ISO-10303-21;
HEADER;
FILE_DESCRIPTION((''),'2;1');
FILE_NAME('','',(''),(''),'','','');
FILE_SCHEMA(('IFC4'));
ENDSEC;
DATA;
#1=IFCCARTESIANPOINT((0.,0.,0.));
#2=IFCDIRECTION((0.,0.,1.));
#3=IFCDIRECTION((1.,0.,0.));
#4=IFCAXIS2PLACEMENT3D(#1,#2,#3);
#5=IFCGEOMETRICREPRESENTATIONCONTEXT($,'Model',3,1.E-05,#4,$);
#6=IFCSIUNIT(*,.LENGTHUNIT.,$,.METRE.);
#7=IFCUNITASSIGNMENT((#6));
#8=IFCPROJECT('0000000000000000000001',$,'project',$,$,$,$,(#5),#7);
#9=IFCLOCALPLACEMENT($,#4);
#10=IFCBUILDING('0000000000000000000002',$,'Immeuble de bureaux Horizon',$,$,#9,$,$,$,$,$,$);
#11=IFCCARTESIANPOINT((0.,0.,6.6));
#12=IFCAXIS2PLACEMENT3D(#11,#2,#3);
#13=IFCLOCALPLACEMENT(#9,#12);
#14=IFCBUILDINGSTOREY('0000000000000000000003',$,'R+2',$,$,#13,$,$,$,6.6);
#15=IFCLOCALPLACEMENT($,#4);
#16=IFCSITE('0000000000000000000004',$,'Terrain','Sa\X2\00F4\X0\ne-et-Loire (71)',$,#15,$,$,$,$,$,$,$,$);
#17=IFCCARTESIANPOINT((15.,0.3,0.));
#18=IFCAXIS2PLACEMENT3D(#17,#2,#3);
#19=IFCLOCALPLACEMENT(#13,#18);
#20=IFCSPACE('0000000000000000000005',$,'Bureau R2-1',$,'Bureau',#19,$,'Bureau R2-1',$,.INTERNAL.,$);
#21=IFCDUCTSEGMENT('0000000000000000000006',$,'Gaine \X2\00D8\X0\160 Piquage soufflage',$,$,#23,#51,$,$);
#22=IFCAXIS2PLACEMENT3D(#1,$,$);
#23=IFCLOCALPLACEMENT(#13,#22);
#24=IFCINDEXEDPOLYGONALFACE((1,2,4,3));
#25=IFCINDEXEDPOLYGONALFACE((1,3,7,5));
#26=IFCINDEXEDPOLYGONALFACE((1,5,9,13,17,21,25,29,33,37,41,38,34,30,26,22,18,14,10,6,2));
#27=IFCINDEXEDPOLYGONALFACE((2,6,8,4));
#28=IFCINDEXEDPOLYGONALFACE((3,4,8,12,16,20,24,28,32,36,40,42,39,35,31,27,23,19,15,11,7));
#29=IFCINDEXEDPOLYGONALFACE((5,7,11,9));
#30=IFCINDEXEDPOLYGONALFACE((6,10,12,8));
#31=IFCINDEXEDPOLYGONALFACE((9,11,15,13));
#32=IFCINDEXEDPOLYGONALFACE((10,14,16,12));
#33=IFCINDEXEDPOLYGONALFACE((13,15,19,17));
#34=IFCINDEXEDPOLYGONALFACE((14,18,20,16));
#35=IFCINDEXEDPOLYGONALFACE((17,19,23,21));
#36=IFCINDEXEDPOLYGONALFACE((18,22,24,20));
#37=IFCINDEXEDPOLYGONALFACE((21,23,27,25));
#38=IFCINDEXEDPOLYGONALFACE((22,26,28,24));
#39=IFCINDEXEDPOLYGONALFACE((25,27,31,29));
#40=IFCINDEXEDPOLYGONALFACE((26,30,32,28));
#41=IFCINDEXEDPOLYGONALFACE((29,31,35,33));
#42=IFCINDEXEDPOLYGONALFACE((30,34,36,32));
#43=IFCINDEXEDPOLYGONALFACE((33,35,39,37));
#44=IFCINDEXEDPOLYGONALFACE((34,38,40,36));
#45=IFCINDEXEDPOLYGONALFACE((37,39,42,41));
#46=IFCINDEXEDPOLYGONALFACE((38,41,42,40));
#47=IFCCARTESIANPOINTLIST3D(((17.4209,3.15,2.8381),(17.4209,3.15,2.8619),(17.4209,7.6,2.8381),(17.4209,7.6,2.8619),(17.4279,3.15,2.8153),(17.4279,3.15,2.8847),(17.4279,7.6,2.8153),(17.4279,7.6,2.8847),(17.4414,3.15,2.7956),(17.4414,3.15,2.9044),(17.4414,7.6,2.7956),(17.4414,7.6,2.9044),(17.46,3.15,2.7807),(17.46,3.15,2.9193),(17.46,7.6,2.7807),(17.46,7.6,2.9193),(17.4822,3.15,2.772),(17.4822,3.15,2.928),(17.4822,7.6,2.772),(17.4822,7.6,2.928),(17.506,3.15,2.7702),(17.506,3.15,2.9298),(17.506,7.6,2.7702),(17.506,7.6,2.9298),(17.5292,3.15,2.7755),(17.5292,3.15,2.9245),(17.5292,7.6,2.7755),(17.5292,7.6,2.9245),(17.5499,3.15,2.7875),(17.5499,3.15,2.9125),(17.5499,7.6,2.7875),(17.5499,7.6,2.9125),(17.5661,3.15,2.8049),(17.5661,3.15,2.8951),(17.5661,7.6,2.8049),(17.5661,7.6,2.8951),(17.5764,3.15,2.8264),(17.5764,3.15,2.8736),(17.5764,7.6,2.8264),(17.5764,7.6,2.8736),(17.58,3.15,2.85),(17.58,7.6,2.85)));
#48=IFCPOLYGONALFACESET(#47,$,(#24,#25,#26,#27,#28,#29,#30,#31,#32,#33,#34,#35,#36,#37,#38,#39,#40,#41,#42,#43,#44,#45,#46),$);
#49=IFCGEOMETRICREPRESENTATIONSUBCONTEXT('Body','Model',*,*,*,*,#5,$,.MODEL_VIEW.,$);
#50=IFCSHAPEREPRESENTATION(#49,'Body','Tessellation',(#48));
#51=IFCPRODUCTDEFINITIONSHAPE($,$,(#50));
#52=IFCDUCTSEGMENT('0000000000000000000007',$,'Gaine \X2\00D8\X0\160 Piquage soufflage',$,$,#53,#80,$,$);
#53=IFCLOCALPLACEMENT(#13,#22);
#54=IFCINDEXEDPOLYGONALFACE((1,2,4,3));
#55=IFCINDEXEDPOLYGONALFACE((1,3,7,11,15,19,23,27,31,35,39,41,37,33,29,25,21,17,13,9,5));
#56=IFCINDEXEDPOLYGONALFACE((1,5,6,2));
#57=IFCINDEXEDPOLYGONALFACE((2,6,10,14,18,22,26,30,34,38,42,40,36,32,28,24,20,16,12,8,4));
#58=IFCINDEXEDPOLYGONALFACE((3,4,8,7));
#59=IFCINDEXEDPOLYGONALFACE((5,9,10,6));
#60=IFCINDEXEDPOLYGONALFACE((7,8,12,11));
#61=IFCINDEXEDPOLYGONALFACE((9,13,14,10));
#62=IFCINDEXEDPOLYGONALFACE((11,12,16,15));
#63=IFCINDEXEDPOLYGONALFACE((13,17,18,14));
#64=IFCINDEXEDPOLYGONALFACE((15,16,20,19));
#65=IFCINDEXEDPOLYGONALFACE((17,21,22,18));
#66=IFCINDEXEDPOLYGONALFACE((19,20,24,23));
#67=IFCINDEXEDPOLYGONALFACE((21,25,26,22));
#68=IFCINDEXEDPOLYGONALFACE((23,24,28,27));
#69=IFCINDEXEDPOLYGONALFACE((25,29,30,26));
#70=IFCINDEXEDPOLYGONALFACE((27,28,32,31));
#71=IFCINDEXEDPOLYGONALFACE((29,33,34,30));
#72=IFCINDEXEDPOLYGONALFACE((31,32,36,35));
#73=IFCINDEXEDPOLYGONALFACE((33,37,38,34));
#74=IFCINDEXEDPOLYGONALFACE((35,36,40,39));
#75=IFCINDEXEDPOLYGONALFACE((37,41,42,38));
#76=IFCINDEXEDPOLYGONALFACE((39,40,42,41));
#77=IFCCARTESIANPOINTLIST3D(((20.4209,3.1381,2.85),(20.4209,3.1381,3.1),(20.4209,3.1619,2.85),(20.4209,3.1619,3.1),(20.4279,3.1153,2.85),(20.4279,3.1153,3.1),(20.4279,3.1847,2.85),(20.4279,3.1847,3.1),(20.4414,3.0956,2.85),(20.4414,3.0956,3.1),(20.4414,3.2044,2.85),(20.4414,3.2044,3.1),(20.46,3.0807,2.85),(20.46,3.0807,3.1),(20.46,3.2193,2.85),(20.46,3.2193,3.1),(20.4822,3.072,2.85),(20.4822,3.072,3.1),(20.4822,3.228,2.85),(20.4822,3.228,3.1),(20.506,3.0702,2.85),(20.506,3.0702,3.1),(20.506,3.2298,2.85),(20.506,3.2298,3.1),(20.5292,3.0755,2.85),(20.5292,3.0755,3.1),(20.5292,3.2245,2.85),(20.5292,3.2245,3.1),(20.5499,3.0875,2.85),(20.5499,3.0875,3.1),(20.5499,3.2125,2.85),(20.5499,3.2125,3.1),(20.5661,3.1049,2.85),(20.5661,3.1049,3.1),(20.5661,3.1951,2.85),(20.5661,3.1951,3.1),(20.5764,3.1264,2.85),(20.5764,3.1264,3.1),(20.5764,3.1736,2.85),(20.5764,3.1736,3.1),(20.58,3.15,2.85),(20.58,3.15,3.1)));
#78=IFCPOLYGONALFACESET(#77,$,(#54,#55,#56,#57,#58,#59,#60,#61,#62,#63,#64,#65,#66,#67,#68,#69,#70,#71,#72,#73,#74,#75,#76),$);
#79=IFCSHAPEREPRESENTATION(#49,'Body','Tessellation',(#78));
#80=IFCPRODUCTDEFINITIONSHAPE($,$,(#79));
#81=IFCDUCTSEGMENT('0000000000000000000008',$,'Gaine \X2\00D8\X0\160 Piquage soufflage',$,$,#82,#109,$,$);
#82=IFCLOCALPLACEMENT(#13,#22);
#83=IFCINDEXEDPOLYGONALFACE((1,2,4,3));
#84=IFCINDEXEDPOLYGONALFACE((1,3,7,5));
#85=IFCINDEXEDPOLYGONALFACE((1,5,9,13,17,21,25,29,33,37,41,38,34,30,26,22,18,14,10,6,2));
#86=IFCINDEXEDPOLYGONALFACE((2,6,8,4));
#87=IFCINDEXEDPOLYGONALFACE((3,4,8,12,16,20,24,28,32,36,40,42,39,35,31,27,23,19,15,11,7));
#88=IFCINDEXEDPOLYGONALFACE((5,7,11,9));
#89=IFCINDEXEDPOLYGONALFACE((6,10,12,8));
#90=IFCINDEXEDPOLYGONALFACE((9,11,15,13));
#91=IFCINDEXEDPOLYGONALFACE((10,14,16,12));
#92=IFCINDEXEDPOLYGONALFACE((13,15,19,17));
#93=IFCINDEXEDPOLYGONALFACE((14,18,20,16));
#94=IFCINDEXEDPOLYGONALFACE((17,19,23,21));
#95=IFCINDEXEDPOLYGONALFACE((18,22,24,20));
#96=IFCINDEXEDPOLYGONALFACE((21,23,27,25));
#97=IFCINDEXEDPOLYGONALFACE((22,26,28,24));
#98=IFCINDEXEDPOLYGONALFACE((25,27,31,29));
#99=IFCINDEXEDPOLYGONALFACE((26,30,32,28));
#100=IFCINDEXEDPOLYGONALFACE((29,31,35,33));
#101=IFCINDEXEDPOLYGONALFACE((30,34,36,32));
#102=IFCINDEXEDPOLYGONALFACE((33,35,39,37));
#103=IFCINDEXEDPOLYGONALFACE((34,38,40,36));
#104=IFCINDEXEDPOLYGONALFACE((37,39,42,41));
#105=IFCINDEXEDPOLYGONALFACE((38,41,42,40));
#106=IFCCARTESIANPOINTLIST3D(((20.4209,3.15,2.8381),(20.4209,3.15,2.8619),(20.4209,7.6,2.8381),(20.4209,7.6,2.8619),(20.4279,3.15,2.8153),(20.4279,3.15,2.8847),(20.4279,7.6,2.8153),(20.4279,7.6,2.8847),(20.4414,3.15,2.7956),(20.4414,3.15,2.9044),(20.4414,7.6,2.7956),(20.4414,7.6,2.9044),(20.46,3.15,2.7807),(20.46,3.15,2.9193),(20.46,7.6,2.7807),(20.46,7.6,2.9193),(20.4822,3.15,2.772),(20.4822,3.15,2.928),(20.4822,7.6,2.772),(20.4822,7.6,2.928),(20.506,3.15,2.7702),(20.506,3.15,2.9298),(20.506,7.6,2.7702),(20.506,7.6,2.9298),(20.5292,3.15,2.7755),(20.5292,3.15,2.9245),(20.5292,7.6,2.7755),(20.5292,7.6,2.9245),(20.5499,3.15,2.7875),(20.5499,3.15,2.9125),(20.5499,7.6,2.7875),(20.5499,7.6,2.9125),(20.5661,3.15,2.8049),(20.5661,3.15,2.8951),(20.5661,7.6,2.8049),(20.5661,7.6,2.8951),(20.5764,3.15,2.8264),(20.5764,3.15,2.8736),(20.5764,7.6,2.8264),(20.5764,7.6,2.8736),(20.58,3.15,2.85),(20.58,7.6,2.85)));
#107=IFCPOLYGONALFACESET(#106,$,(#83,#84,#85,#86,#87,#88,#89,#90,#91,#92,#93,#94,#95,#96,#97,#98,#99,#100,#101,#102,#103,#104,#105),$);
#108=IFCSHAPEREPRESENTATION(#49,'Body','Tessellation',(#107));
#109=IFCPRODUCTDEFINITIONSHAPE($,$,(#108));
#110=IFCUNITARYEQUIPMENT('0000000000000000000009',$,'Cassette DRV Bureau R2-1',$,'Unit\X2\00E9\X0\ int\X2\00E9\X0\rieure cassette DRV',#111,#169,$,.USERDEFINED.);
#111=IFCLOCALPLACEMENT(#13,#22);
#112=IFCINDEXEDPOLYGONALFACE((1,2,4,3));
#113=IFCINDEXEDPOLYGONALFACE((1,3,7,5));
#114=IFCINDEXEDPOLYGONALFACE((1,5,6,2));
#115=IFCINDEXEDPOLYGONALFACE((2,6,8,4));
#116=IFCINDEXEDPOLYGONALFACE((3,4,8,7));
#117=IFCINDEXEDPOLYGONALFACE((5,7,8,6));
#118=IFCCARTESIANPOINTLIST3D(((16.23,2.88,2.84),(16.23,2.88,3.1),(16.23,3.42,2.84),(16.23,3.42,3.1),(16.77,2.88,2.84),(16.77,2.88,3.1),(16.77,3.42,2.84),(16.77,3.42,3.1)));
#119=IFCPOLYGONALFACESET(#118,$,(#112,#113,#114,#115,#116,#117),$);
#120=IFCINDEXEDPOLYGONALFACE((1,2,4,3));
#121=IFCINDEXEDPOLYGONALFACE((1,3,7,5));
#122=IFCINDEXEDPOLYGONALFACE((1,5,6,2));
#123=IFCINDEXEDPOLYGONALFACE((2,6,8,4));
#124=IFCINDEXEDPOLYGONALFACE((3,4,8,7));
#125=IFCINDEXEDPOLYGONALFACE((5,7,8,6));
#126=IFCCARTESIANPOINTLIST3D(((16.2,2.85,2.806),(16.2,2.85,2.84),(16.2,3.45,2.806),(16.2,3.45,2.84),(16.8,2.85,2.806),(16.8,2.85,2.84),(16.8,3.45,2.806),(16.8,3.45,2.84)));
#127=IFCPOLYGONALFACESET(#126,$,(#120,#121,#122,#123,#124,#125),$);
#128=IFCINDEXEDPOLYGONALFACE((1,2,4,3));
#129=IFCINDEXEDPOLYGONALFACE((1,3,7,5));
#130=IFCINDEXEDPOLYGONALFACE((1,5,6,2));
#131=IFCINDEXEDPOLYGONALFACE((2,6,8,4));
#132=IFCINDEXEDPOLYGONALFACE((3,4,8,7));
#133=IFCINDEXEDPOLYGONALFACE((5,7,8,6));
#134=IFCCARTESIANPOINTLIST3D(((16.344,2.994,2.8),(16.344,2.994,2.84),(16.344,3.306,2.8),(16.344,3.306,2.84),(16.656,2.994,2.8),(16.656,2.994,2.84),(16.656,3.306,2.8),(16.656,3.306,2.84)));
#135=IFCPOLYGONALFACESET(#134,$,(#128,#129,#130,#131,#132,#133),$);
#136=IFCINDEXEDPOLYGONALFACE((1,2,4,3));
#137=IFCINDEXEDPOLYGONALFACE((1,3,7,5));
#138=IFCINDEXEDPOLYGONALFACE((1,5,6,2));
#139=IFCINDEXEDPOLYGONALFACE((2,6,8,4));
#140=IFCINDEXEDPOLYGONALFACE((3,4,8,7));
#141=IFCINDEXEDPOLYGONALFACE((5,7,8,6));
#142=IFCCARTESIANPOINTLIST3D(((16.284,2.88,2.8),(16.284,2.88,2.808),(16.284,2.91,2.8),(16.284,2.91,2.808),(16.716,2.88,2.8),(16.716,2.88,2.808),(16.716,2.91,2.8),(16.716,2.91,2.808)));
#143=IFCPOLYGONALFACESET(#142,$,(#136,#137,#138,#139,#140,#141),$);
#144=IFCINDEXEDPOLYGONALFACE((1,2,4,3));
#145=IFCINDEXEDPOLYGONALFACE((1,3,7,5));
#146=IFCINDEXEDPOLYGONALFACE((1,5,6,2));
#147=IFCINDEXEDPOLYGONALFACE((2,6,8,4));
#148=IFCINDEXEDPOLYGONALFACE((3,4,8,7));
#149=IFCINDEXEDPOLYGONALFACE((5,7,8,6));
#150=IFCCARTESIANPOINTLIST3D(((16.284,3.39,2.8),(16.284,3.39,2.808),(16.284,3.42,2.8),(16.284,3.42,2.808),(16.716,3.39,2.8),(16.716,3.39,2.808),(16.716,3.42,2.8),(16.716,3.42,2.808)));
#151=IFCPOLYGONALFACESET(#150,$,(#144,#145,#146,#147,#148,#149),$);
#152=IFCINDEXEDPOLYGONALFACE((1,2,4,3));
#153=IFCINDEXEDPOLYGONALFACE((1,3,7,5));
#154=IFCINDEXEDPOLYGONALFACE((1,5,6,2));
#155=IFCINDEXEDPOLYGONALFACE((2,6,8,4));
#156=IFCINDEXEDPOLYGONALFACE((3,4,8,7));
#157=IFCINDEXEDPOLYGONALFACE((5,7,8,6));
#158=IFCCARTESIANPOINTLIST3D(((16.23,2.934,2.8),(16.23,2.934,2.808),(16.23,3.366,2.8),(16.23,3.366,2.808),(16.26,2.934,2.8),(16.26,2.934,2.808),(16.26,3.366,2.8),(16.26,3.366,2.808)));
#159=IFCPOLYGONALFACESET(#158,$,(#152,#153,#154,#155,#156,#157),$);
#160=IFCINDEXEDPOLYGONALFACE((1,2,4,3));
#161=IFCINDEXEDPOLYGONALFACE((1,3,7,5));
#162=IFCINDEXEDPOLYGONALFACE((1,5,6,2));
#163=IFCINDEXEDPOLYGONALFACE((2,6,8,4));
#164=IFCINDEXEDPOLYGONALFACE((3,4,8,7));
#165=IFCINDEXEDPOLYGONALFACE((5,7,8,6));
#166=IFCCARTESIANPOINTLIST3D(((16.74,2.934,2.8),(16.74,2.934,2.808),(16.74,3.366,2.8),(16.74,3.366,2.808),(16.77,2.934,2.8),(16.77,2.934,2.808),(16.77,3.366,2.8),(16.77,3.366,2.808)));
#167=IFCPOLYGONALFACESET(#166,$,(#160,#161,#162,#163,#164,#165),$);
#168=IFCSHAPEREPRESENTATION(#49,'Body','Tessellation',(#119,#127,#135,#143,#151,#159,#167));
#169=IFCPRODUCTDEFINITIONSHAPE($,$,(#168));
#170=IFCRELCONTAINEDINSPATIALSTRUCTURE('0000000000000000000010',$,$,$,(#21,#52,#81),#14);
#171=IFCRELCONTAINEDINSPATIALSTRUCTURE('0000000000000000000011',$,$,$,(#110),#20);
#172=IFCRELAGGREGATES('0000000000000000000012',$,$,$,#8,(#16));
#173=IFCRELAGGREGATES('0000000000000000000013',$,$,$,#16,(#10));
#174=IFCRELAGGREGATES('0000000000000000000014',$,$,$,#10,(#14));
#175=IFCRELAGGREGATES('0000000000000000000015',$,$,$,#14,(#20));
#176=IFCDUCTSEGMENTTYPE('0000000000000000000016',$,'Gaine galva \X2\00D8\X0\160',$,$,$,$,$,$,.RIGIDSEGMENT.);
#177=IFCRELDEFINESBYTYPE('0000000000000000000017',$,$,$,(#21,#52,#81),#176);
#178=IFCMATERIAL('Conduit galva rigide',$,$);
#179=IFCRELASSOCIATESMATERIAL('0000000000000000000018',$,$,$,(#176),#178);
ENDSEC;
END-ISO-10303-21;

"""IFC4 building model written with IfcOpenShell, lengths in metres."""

from ifc_helpers import new_model, si_unit, frame, frame_2d, origin_with_axes, place, context, subcontext, project, spatial, rectangle, circle, extrude, material, type_object, element, save


model = new_model("IFC4")

# Units and contexts
model_context = context("Model", 3, precision=1e-05, world=origin_with_axes())
body_context = subcontext(model_context, "Body", "Model", "MODEL_VIEW")
ifc_project = project(units=[si_unit("LENGTHUNIT", "METRE")], contexts=[model_context])

# Site, building, storey
site_placement = place(None, origin_with_axes())
site = spatial("IfcSite", under=ifc_project, at=site_placement, Name="Terrain", Description="Saône-et-Loire (71)")
building_placement = place(None, origin_with_axes())
building = spatial("IfcBuilding", under=site, at=building_placement, Name="Immeuble de bureaux Horizon")
storey_placement = place(building_placement, frame((0.0, 0.0, 6.6), z_axis=(0.0, 0.0, 1.0), x_axis=(1.0, 0.0, 0.0)))
storey = spatial("IfcBuildingStorey", under=building, at=storey_placement, Name="R+2", Elevation=6.6)

# Duct segments
ifc_material_1 = material(Name="Conduit galva rigide")
duct_segment_type = type_object("IfcDuctSegmentType", Name="Gaine galva Ø160", PredefinedType="RIGIDSEGMENT", material=ifc_material_1)
duct_segment_1_placement = place(storey_placement, frame((17.5, 3.15, 2.85), z_axis=(0.0, 1.0, 0.0), x_axis=(1.0, 0.0, 0.0)))
element("IfcDuctSegment", 1, at=duct_segment_1_placement, inside=storey, type_object=duct_segment_type, Name="Gaine Ø160 Piquage soufflage", context=body_context, shape_type="SweptSolid", body=[
    extrude(circle(Radius=0.08), origin_with_axes(), (0.0, 0.0, 1.0), 4.45),
])
duct_segment_2_placement = place(storey_placement, frame((20.5, 3.15, 3.1), z_axis=(0.0, 0.0, -1.0), x_axis=(1.0, 0.0, 0.0)))
element("IfcDuctSegment", 2, at=duct_segment_2_placement, inside=storey, type_object=duct_segment_type, Name="Gaine Ø160 Piquage soufflage", context=body_context, shape_type="SweptSolid", body=[
    extrude(circle(Radius=0.08), origin_with_axes(), (0.0, 0.0, 1.0), 0.25),
])
duct_segment_3_placement = place(storey_placement, frame((20.5, 3.15, 2.85), z_axis=(0.0, 1.0, 0.0), x_axis=(1.0, 0.0, 0.0)))
element("IfcDuctSegment", 3, at=duct_segment_3_placement, inside=storey, type_object=duct_segment_type, Name="Gaine Ø160 Piquage soufflage", context=body_context, shape_type="SweptSolid", body=[
    extrude(circle(Radius=0.08), origin_with_axes(), (0.0, 0.0, 1.0), 4.45),
])

# Shared definitions
space_1_placement = place(storey_placement, frame((15.0, 0.3, 0.0), z_axis=(0.0, 0.0, 1.0), x_axis=(1.0, 0.0, 0.0)))
space_1 = spatial("IfcSpace", under=storey, at=space_1_placement, Name="Bureau R2-1", ObjectType="Bureau", LongName="Bureau R2-1", PredefinedType="INTERNAL")

# Unitary equipment
unitary_equipment_1_placement = place(space_1_placement, frame((1.2, 2.55, 2.8), z_axis=(0.0, 0.0, 1.0), x_axis=(1.0, 0.0, 0.0)))
element("IfcUnitaryEquipment", 4, at=unitary_equipment_1_placement, inside=space_1, Name="Cassette DRV Bureau R2-1", ObjectType="Unité intérieure cassette DRV", PredefinedType="USERDEFINED", context=body_context, shape_type="SweptSolid", body=[
    extrude(rectangle(XDim=0.54, YDim=0.54, at=frame_2d((0.27, 0.27))), frame((0.03, 0.03, 0.04), z_axis=(0.0, 0.0, 1.0), x_axis=(1.0, 0.0, 0.0)), (0.0, 0.0, 1.0), 0.26),
    extrude(rectangle(XDim=0.6, YDim=0.6, at=frame_2d((0.3, 0.3))), frame((0.0, 0.0, 0.006), z_axis=(0.0, 0.0, 1.0), x_axis=(1.0, 0.0, 0.0)), (0.0, 0.0, 1.0), 0.034),
    extrude(rectangle(XDim=0.312, YDim=0.312, at=frame_2d((0.156, 0.156))), frame((0.144, 0.144, 0.0), z_axis=(0.0, 0.0, 1.0), x_axis=(1.0, 0.0, 0.0)), (0.0, 0.0, 1.0), 0.04),
    extrude(rectangle(XDim=0.432, YDim=0.03, at=frame_2d((0.216, 0.015))), frame((0.084, 0.03, 0.0), z_axis=(0.0, 0.0, 1.0), x_axis=(1.0, 0.0, 0.0)), (0.0, 0.0, 1.0), 0.008),
    extrude(rectangle(XDim=0.432, YDim=0.03, at=frame_2d((0.216, 0.015))), frame((0.084, 0.54, 0.0), z_axis=(0.0, 0.0, 1.0), x_axis=(1.0, 0.0, 0.0)), (0.0, 0.0, 1.0), 0.008),
    extrude(rectangle(XDim=0.03, YDim=0.432, at=frame_2d((0.015, 0.216))), frame((0.03, 0.084, 0.0), z_axis=(0.0, 0.0, 1.0), x_axis=(1.0, 0.0, 0.0)), (0.0, 0.0, 1.0), 0.008),
    extrude(rectangle(XDim=0.03, YDim=0.432, at=frame_2d((0.015, 0.216))), frame((0.54, 0.084, 0.0), z_axis=(0.0, 0.0, 1.0), x_axis=(1.0, 0.0, 0.0)), (0.0, 0.0, 1.0), 0.008),
])

save(model, "model.ifc")
